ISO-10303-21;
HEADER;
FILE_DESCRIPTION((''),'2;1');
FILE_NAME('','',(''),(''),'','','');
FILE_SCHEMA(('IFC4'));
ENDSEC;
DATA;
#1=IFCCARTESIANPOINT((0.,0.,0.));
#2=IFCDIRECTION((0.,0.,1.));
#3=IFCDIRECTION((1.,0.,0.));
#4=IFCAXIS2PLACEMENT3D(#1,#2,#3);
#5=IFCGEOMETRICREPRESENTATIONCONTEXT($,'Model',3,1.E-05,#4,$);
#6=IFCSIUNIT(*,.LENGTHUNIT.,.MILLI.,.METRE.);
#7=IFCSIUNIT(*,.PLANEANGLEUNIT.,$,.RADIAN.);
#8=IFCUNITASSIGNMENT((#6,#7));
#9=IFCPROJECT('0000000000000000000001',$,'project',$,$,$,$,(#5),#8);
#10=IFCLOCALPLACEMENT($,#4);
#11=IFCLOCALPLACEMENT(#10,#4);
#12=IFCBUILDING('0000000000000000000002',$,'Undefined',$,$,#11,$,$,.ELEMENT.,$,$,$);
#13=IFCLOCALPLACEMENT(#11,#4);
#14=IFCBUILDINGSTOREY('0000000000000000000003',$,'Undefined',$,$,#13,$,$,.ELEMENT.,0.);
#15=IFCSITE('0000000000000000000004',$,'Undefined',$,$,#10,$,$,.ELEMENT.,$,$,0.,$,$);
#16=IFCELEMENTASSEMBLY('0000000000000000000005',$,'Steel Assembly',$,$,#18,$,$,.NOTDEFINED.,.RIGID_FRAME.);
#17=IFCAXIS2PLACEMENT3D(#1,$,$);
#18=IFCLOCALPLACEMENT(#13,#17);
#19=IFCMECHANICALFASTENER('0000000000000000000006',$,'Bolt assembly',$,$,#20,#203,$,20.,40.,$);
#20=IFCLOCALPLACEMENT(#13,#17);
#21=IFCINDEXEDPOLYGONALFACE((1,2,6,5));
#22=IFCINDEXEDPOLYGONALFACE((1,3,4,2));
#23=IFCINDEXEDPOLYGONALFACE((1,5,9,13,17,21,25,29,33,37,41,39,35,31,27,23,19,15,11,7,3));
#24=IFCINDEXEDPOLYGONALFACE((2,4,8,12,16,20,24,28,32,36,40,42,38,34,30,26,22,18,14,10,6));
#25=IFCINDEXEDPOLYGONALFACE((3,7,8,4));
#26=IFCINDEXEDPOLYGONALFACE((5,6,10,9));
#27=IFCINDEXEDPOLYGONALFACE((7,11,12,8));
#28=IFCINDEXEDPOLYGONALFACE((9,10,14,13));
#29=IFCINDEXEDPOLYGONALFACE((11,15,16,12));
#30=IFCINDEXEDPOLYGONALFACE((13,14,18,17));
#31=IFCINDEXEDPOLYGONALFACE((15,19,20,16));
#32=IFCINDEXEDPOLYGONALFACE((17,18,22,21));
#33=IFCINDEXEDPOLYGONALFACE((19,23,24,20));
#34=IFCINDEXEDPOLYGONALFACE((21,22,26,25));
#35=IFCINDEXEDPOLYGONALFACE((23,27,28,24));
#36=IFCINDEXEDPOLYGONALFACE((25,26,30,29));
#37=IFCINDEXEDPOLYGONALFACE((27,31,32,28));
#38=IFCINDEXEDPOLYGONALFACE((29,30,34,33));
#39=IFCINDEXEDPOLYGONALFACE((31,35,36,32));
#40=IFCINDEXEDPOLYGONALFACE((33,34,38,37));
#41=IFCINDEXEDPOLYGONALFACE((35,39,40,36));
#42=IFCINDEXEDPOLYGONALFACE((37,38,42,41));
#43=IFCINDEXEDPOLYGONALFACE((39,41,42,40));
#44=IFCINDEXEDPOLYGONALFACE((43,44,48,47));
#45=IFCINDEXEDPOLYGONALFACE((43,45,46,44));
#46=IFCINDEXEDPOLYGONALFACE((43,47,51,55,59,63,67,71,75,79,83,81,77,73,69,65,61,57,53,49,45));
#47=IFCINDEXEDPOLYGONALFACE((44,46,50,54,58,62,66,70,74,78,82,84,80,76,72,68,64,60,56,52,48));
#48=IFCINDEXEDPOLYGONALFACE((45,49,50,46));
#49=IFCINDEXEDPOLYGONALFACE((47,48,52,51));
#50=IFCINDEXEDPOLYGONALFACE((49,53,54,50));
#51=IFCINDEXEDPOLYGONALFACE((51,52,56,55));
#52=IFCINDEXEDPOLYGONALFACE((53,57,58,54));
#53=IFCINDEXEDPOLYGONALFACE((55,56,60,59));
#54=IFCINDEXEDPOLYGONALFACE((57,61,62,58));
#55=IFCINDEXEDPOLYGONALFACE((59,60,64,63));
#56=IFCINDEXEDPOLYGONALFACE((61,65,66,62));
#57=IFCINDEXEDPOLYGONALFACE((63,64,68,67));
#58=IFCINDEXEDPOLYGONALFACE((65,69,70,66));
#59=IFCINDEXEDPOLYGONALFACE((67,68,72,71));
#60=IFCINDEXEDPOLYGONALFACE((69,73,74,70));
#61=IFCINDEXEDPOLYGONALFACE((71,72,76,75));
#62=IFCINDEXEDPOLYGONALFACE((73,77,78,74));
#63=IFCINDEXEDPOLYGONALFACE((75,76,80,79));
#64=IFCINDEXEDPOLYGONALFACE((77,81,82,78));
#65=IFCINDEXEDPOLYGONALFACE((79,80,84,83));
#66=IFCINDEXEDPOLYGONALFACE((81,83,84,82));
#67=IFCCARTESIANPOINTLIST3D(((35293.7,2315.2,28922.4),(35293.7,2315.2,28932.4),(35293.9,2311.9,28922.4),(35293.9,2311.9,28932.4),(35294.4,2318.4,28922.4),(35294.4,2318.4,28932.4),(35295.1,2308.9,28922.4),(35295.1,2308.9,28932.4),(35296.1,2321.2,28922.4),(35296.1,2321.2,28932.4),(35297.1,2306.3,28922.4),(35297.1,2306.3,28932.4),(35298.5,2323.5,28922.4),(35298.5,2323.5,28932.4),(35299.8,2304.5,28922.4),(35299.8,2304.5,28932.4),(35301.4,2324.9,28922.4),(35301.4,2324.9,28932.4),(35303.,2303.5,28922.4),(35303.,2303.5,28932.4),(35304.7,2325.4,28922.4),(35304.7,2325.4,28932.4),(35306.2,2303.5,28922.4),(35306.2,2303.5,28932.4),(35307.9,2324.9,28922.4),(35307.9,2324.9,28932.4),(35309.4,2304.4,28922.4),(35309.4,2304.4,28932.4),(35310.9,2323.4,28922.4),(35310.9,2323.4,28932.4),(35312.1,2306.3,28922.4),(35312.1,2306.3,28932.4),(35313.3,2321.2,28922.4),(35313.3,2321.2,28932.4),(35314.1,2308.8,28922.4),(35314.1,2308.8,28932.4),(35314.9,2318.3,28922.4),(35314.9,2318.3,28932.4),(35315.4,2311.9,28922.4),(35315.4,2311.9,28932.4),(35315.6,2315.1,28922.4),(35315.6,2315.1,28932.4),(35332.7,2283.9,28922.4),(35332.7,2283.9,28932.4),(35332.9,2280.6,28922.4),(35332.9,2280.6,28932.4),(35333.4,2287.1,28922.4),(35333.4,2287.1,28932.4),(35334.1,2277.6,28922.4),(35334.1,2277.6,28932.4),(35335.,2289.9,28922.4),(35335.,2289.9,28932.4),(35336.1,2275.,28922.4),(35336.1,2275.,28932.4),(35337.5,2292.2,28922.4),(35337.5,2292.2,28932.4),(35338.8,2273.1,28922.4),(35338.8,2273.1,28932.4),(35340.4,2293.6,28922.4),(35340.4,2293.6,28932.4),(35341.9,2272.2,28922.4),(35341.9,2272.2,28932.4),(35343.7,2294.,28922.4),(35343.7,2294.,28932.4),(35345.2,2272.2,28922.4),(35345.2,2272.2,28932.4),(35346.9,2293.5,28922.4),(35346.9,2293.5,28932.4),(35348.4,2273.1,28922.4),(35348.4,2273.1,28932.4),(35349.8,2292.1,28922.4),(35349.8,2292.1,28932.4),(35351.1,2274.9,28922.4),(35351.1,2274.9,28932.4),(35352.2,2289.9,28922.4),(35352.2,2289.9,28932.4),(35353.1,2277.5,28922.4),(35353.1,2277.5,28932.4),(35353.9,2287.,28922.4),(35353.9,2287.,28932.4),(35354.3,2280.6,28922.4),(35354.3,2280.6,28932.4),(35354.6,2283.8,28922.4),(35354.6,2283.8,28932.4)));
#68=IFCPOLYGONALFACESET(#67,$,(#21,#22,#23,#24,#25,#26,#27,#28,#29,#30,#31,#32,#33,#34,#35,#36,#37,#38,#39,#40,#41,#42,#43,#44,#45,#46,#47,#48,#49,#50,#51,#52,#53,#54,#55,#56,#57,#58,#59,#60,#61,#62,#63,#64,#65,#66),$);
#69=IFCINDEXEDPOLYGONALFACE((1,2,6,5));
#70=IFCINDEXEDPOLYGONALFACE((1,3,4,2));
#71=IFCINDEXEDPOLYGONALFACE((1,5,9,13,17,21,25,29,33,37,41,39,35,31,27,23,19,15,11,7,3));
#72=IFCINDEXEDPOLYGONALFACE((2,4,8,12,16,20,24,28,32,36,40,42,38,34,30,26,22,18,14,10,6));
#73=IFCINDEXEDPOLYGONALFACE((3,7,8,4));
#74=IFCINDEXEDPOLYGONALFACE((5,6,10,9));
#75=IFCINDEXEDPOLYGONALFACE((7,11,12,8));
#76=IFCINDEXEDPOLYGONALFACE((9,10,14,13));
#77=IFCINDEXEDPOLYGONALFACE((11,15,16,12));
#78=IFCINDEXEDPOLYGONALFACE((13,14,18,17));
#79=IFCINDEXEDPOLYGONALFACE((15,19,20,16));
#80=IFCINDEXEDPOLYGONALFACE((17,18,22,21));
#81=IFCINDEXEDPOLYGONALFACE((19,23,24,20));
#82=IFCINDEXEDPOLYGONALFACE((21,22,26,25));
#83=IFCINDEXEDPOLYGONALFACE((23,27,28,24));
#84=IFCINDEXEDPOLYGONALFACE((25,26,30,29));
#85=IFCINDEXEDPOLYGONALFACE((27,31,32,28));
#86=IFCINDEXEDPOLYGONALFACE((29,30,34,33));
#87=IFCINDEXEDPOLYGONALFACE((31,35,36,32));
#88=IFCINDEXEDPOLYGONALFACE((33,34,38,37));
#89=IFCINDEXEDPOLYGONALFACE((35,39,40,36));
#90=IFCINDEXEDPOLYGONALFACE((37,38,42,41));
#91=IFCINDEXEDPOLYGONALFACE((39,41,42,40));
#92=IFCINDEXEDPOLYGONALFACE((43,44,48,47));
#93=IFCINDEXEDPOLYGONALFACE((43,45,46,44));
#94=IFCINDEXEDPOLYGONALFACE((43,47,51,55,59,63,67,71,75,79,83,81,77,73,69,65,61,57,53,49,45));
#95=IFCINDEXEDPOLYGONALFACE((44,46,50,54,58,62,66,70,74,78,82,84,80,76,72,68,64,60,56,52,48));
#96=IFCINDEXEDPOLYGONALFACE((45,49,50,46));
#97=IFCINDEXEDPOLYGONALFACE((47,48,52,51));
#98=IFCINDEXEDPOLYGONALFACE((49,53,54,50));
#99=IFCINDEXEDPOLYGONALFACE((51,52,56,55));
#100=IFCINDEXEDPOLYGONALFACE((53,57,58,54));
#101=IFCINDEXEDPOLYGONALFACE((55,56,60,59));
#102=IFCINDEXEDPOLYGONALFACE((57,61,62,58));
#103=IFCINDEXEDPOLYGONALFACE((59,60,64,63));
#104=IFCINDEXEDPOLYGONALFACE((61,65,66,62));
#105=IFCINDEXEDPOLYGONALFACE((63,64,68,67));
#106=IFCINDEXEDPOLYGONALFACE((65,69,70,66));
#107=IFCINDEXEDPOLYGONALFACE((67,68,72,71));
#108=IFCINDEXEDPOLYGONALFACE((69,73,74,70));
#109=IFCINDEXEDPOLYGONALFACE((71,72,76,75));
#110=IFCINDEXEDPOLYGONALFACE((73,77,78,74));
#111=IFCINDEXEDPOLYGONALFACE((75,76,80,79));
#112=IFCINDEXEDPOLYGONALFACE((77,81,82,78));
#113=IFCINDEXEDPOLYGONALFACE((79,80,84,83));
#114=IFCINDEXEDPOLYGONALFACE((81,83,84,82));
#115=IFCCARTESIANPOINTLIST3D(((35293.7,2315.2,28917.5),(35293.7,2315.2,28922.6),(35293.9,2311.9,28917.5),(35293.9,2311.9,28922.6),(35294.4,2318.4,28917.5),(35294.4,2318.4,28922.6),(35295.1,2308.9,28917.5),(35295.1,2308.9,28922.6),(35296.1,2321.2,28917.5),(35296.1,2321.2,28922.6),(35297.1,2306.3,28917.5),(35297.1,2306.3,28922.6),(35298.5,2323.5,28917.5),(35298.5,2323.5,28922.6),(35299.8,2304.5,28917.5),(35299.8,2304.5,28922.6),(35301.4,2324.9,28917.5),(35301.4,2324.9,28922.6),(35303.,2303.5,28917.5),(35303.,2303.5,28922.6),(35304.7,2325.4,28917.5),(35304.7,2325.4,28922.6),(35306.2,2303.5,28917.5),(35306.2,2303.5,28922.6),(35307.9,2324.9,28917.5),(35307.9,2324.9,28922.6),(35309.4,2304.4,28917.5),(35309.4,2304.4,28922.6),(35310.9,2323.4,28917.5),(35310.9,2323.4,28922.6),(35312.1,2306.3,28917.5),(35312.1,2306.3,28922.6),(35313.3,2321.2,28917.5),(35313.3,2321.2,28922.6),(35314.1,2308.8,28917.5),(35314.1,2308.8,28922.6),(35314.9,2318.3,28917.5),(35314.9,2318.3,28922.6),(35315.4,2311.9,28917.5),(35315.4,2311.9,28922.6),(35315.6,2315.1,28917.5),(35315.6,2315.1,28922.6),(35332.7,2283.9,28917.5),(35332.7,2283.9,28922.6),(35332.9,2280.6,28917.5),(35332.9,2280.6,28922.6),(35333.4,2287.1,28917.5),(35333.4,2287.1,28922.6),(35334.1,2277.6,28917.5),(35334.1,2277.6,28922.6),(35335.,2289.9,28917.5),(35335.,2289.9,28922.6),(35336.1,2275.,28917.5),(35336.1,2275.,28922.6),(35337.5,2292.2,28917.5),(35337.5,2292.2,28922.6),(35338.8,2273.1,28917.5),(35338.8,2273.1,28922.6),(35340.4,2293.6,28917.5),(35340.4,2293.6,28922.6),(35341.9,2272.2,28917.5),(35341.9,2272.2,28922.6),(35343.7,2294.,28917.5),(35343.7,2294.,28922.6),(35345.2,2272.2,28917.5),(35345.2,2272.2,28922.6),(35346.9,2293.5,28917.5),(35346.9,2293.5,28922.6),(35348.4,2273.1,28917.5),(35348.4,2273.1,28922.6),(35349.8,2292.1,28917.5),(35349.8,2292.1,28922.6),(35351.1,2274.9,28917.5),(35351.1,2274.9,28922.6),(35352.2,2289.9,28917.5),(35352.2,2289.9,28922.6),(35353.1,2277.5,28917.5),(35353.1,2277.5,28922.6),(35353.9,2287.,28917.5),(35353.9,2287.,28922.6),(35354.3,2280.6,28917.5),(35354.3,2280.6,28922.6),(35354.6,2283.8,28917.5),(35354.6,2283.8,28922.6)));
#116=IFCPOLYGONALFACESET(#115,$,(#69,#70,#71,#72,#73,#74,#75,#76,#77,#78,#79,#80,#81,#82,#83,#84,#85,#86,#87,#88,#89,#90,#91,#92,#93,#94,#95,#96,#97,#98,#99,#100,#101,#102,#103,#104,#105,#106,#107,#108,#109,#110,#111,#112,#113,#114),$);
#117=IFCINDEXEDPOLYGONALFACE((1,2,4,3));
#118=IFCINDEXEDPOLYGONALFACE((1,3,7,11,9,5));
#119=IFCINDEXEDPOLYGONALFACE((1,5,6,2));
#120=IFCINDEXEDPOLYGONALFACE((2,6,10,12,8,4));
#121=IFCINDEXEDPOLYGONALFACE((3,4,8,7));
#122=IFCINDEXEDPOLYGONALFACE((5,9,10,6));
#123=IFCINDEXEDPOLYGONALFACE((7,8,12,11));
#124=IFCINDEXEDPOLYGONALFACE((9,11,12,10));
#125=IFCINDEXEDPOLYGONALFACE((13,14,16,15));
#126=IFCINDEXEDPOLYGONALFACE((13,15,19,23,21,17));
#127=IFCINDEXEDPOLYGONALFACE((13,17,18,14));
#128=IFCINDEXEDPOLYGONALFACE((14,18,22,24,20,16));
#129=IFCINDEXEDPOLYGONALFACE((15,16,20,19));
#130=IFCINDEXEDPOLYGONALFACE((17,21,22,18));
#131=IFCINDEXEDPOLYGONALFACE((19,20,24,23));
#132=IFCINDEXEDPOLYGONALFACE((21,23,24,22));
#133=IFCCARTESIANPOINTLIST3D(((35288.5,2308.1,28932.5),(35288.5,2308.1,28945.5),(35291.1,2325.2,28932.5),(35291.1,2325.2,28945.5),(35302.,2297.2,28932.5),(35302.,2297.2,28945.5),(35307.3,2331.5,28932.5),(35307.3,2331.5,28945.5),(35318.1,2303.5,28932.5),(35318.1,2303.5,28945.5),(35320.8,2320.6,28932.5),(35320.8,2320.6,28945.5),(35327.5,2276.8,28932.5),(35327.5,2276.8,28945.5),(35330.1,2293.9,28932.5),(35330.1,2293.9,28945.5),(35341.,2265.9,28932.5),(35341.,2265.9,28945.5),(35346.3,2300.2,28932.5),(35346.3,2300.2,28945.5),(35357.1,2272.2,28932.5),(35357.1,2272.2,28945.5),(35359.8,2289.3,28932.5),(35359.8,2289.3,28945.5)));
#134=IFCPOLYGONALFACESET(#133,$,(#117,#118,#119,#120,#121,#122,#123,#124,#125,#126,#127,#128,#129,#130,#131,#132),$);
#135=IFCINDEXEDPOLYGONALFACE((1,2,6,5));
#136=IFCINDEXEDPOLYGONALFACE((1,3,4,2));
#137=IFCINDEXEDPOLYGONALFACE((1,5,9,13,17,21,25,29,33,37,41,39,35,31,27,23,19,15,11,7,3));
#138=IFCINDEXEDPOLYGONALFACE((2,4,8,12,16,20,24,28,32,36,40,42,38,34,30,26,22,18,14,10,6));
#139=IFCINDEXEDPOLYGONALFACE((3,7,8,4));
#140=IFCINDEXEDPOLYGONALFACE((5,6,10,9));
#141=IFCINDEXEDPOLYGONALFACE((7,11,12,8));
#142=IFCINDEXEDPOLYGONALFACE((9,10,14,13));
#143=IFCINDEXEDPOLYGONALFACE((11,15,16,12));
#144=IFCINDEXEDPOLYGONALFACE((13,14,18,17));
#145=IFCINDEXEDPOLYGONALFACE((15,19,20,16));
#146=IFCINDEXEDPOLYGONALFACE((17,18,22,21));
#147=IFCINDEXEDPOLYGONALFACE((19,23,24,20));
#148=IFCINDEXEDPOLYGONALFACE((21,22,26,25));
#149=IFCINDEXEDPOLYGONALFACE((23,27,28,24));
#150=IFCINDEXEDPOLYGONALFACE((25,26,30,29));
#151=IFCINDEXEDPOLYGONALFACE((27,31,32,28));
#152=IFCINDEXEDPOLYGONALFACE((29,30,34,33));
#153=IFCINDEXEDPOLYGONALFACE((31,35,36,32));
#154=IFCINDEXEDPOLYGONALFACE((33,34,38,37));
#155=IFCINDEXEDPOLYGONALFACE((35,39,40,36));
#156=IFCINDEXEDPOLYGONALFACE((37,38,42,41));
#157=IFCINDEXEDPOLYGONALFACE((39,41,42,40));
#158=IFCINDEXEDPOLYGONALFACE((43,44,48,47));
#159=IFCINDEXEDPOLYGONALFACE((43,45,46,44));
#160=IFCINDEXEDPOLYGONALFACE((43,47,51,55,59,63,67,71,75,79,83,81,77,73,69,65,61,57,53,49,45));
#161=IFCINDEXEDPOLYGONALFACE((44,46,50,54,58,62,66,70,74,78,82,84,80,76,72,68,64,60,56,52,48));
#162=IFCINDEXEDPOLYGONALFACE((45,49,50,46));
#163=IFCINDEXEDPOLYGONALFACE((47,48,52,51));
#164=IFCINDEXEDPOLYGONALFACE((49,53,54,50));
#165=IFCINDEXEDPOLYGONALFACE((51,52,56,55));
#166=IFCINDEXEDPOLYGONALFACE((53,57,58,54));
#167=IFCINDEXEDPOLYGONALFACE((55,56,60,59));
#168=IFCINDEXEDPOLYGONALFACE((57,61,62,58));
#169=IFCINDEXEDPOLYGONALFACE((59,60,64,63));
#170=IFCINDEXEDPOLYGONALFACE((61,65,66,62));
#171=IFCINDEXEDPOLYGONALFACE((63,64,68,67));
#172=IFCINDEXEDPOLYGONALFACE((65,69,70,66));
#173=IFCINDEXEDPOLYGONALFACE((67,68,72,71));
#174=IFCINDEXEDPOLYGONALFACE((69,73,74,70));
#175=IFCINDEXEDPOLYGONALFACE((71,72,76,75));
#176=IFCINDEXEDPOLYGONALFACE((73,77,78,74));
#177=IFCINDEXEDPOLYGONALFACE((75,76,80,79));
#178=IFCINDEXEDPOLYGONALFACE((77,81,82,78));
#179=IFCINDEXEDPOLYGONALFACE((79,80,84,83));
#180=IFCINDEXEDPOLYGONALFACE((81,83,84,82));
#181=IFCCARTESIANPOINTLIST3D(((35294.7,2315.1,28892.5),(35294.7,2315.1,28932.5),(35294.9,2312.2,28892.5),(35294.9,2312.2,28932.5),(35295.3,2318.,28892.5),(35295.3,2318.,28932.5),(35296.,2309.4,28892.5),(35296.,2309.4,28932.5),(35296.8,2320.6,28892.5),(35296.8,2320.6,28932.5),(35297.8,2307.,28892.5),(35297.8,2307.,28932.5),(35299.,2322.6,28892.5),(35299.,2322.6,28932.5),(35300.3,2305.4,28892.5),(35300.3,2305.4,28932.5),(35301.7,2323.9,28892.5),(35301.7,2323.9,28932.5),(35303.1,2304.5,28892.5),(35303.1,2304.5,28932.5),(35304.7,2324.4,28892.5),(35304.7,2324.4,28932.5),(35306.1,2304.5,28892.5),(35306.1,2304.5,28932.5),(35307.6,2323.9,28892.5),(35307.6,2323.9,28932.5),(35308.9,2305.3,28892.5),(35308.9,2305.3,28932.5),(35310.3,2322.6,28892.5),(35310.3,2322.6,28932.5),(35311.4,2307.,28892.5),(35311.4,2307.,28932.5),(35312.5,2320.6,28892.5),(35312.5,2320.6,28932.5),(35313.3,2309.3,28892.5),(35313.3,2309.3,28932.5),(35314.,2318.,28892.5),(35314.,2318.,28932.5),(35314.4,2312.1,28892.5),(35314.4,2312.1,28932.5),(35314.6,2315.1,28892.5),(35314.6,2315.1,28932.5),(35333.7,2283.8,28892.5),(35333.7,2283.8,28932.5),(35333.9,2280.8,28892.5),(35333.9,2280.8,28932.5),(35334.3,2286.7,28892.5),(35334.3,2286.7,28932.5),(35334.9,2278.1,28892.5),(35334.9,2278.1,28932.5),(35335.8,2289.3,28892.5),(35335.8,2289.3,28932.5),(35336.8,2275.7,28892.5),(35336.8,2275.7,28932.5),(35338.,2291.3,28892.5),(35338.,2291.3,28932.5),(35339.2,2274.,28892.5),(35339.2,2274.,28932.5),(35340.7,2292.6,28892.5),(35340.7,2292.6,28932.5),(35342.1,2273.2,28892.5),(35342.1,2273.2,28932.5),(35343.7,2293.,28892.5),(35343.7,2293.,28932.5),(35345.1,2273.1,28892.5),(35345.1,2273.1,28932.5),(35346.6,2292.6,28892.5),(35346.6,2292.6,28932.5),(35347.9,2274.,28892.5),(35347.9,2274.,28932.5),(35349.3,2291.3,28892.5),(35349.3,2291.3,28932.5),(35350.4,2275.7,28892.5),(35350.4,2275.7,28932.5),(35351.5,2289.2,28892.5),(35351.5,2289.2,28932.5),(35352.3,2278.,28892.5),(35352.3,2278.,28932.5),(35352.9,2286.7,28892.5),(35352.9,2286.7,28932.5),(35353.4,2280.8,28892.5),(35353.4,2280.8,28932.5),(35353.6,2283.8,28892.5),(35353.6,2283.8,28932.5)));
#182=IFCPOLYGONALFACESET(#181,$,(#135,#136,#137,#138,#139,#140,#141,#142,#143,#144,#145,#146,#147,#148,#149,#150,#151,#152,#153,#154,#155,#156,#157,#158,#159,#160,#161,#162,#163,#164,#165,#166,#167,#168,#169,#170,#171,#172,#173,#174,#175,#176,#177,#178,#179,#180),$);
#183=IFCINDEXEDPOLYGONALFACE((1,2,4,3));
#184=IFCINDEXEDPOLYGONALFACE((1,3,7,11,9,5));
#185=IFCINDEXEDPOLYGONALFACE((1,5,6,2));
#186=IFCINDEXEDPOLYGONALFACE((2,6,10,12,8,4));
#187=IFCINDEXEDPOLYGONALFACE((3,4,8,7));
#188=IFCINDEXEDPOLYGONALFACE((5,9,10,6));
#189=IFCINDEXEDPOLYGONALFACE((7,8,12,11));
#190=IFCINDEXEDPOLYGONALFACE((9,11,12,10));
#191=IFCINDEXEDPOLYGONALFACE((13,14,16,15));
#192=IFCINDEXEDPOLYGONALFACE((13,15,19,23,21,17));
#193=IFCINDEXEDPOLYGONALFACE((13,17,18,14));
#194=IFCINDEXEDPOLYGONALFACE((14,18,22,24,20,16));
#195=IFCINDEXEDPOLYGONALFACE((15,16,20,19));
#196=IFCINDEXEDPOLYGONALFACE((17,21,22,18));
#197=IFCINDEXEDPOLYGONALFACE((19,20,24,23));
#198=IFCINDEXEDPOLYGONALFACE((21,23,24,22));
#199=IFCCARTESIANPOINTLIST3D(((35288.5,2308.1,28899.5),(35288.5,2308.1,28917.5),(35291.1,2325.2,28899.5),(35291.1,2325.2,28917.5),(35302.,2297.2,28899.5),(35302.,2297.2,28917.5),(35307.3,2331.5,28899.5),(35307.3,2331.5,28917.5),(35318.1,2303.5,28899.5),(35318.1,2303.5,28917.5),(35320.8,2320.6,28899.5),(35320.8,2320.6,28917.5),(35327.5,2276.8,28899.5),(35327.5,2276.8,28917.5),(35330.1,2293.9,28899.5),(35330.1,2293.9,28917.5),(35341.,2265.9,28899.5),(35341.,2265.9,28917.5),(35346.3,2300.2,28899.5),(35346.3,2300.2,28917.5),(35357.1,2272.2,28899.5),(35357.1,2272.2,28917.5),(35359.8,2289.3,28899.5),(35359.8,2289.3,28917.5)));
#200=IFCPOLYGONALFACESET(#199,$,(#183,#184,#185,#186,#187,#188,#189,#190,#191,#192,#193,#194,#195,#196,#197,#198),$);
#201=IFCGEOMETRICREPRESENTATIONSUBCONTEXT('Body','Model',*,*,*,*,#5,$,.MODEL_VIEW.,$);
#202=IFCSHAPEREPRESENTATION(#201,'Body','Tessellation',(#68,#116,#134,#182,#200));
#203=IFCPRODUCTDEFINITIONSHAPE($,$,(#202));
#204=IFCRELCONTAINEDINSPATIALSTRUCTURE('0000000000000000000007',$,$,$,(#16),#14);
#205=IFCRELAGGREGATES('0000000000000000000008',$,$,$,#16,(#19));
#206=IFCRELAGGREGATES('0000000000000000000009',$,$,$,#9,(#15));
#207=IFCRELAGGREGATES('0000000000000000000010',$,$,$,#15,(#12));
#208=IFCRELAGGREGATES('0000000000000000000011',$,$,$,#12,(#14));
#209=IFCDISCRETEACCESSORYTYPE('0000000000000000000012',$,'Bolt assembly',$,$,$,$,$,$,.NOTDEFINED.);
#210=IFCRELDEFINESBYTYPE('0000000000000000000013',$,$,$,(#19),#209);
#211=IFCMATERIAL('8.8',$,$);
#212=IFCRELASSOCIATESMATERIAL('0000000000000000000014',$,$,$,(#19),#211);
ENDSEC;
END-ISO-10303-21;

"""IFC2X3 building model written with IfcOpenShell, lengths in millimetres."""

from ifc_helpers import new_model, si_unit, frame, origin_with_axes, origin_2d_with_axis, place, context, subcontext, project, spatial, polyline, circle, outline, extrude, source, transform, mapped, material, type_object, element, aggregate, save


model = new_model("IFC2X3")

# Units and contexts
model_context = context("Model", 3, precision=1e-05, world=origin_with_axes())
body_context = subcontext(model_context, "Body", "Model", "MODEL_VIEW")
ifc_project = project(units=[si_unit("LENGTHUNIT", "METRE", prefix="MILLI"), si_unit("PLANEANGLEUNIT", "RADIAN")], contexts=[model_context])

# Site, building, storey
site_placement = place(None, origin_with_axes())
site = spatial("IfcSite", under=ifc_project, at=site_placement, Name="Undefined", CompositionType="ELEMENT", RefElevation=0.0)
building_placement = place(site_placement, origin_with_axes())
building = spatial("IfcBuilding", under=site, at=building_placement, Name="Undefined", CompositionType="ELEMENT")
storey_placement = place(building_placement, origin_with_axes())
storey = spatial("IfcBuildingStorey", under=building, at=storey_placement, Name="Undefined", CompositionType="ELEMENT", Elevation=0.0)

# Element assembly
assembly_1_placement = place(storey_placement, origin_with_axes())
assembly_1 = element("IfcElementAssembly", 1, at=assembly_1_placement, inside=storey, Name="Steel Assembly", AssemblyPlace="NOTDEFINED", PredefinedType="RIGID_FRAME")

# Shared definitions
discrete_accessory_type_1 = type_object("IfcDiscreteAccessoryType", Name="Bolt assembly")
ifc_material_1 = material(Name="8.8")

# Mechanical fastener
shared_shape_1 = source(origin_with_axes(), body_context, "Body", "SweptSolid", [
    extrude(circle(Radius=11.0, at=origin_2d_with_axis()), frame((0.0, -9.9, 0.0), z_axis=(0.0, 1.0, 0.0), x_axis=(1.0, 0.0, 0.0)), (0.0, 0.0, 1.0), 10.0),
    extrude(circle(Radius=11.0, at=origin_2d_with_axis()), frame((0.0, -0.1, 0.0), z_axis=(0.0, 1.0, 0.0), x_axis=(1.0, 0.0, 0.0)), (0.0, 0.0, 1.0), 5.1),
    extrude(outline(polyline([(17.3, 0.0), (8.7, 15.0), (-8.7, 15.0), (-17.3, 0.0), (-8.7, -15.0), (8.7, -15.0), (17.3, 0.0)])), frame((0.0, -23.0, 0.0), z_axis=(0.0, 1.0, 0.0), x_axis=(1.0, 0.0, 0.0)), (0.0, 0.0, 1.0), 13.0),
    extrude(circle(Radius=10.0, at=origin_2d_with_axis()), frame((0.0, -10.0, 0.0), z_axis=(0.0, 1.0, 0.0), x_axis=(1.0, 0.0, 0.0)), (0.0, 0.0, 1.0), 40.0),
    extrude(outline(polyline([(17.3, 0.0), (8.7, 15.0), (-8.7, 15.0), (-17.3, 0.0), (-8.7, -15.0), (8.7, -15.0), (17.3, 0.0)])), frame((0.0, 5.0, 0.0), z_axis=(0.0, 1.0, 0.0), x_axis=(1.0, 0.0, 0.0)), (0.0, 0.0, 1.0), 18.0),
])
mechanical_fastener_1_placement = place(assembly_1_placement, frame((35343.6, 2283.0, 28922.5), z_axis=(-0.6263, -0.779582, 0.0), x_axis=(-0.779582, 0.6263, 0.0)))
mechanical_fastener_1 = element("IfcMechanicalFastener", 2, at=mechanical_fastener_1_placement, type_object=discrete_accessory_type_1, material=ifc_material_1, Name="Bolt assembly", NominalDiameter=20.0, NominalLength=40.0, context=body_context, shape_type="MappedRepresentation", body=[
    mapped(shared_shape_1, transform((0.0, 0.0, 0.0))),
    mapped(shared_shape_1, transform((50.0, 0.0, 0.0))),
])
aggregate(assembly_1, [mechanical_fastener_1])

save(model, "model.ifc")
